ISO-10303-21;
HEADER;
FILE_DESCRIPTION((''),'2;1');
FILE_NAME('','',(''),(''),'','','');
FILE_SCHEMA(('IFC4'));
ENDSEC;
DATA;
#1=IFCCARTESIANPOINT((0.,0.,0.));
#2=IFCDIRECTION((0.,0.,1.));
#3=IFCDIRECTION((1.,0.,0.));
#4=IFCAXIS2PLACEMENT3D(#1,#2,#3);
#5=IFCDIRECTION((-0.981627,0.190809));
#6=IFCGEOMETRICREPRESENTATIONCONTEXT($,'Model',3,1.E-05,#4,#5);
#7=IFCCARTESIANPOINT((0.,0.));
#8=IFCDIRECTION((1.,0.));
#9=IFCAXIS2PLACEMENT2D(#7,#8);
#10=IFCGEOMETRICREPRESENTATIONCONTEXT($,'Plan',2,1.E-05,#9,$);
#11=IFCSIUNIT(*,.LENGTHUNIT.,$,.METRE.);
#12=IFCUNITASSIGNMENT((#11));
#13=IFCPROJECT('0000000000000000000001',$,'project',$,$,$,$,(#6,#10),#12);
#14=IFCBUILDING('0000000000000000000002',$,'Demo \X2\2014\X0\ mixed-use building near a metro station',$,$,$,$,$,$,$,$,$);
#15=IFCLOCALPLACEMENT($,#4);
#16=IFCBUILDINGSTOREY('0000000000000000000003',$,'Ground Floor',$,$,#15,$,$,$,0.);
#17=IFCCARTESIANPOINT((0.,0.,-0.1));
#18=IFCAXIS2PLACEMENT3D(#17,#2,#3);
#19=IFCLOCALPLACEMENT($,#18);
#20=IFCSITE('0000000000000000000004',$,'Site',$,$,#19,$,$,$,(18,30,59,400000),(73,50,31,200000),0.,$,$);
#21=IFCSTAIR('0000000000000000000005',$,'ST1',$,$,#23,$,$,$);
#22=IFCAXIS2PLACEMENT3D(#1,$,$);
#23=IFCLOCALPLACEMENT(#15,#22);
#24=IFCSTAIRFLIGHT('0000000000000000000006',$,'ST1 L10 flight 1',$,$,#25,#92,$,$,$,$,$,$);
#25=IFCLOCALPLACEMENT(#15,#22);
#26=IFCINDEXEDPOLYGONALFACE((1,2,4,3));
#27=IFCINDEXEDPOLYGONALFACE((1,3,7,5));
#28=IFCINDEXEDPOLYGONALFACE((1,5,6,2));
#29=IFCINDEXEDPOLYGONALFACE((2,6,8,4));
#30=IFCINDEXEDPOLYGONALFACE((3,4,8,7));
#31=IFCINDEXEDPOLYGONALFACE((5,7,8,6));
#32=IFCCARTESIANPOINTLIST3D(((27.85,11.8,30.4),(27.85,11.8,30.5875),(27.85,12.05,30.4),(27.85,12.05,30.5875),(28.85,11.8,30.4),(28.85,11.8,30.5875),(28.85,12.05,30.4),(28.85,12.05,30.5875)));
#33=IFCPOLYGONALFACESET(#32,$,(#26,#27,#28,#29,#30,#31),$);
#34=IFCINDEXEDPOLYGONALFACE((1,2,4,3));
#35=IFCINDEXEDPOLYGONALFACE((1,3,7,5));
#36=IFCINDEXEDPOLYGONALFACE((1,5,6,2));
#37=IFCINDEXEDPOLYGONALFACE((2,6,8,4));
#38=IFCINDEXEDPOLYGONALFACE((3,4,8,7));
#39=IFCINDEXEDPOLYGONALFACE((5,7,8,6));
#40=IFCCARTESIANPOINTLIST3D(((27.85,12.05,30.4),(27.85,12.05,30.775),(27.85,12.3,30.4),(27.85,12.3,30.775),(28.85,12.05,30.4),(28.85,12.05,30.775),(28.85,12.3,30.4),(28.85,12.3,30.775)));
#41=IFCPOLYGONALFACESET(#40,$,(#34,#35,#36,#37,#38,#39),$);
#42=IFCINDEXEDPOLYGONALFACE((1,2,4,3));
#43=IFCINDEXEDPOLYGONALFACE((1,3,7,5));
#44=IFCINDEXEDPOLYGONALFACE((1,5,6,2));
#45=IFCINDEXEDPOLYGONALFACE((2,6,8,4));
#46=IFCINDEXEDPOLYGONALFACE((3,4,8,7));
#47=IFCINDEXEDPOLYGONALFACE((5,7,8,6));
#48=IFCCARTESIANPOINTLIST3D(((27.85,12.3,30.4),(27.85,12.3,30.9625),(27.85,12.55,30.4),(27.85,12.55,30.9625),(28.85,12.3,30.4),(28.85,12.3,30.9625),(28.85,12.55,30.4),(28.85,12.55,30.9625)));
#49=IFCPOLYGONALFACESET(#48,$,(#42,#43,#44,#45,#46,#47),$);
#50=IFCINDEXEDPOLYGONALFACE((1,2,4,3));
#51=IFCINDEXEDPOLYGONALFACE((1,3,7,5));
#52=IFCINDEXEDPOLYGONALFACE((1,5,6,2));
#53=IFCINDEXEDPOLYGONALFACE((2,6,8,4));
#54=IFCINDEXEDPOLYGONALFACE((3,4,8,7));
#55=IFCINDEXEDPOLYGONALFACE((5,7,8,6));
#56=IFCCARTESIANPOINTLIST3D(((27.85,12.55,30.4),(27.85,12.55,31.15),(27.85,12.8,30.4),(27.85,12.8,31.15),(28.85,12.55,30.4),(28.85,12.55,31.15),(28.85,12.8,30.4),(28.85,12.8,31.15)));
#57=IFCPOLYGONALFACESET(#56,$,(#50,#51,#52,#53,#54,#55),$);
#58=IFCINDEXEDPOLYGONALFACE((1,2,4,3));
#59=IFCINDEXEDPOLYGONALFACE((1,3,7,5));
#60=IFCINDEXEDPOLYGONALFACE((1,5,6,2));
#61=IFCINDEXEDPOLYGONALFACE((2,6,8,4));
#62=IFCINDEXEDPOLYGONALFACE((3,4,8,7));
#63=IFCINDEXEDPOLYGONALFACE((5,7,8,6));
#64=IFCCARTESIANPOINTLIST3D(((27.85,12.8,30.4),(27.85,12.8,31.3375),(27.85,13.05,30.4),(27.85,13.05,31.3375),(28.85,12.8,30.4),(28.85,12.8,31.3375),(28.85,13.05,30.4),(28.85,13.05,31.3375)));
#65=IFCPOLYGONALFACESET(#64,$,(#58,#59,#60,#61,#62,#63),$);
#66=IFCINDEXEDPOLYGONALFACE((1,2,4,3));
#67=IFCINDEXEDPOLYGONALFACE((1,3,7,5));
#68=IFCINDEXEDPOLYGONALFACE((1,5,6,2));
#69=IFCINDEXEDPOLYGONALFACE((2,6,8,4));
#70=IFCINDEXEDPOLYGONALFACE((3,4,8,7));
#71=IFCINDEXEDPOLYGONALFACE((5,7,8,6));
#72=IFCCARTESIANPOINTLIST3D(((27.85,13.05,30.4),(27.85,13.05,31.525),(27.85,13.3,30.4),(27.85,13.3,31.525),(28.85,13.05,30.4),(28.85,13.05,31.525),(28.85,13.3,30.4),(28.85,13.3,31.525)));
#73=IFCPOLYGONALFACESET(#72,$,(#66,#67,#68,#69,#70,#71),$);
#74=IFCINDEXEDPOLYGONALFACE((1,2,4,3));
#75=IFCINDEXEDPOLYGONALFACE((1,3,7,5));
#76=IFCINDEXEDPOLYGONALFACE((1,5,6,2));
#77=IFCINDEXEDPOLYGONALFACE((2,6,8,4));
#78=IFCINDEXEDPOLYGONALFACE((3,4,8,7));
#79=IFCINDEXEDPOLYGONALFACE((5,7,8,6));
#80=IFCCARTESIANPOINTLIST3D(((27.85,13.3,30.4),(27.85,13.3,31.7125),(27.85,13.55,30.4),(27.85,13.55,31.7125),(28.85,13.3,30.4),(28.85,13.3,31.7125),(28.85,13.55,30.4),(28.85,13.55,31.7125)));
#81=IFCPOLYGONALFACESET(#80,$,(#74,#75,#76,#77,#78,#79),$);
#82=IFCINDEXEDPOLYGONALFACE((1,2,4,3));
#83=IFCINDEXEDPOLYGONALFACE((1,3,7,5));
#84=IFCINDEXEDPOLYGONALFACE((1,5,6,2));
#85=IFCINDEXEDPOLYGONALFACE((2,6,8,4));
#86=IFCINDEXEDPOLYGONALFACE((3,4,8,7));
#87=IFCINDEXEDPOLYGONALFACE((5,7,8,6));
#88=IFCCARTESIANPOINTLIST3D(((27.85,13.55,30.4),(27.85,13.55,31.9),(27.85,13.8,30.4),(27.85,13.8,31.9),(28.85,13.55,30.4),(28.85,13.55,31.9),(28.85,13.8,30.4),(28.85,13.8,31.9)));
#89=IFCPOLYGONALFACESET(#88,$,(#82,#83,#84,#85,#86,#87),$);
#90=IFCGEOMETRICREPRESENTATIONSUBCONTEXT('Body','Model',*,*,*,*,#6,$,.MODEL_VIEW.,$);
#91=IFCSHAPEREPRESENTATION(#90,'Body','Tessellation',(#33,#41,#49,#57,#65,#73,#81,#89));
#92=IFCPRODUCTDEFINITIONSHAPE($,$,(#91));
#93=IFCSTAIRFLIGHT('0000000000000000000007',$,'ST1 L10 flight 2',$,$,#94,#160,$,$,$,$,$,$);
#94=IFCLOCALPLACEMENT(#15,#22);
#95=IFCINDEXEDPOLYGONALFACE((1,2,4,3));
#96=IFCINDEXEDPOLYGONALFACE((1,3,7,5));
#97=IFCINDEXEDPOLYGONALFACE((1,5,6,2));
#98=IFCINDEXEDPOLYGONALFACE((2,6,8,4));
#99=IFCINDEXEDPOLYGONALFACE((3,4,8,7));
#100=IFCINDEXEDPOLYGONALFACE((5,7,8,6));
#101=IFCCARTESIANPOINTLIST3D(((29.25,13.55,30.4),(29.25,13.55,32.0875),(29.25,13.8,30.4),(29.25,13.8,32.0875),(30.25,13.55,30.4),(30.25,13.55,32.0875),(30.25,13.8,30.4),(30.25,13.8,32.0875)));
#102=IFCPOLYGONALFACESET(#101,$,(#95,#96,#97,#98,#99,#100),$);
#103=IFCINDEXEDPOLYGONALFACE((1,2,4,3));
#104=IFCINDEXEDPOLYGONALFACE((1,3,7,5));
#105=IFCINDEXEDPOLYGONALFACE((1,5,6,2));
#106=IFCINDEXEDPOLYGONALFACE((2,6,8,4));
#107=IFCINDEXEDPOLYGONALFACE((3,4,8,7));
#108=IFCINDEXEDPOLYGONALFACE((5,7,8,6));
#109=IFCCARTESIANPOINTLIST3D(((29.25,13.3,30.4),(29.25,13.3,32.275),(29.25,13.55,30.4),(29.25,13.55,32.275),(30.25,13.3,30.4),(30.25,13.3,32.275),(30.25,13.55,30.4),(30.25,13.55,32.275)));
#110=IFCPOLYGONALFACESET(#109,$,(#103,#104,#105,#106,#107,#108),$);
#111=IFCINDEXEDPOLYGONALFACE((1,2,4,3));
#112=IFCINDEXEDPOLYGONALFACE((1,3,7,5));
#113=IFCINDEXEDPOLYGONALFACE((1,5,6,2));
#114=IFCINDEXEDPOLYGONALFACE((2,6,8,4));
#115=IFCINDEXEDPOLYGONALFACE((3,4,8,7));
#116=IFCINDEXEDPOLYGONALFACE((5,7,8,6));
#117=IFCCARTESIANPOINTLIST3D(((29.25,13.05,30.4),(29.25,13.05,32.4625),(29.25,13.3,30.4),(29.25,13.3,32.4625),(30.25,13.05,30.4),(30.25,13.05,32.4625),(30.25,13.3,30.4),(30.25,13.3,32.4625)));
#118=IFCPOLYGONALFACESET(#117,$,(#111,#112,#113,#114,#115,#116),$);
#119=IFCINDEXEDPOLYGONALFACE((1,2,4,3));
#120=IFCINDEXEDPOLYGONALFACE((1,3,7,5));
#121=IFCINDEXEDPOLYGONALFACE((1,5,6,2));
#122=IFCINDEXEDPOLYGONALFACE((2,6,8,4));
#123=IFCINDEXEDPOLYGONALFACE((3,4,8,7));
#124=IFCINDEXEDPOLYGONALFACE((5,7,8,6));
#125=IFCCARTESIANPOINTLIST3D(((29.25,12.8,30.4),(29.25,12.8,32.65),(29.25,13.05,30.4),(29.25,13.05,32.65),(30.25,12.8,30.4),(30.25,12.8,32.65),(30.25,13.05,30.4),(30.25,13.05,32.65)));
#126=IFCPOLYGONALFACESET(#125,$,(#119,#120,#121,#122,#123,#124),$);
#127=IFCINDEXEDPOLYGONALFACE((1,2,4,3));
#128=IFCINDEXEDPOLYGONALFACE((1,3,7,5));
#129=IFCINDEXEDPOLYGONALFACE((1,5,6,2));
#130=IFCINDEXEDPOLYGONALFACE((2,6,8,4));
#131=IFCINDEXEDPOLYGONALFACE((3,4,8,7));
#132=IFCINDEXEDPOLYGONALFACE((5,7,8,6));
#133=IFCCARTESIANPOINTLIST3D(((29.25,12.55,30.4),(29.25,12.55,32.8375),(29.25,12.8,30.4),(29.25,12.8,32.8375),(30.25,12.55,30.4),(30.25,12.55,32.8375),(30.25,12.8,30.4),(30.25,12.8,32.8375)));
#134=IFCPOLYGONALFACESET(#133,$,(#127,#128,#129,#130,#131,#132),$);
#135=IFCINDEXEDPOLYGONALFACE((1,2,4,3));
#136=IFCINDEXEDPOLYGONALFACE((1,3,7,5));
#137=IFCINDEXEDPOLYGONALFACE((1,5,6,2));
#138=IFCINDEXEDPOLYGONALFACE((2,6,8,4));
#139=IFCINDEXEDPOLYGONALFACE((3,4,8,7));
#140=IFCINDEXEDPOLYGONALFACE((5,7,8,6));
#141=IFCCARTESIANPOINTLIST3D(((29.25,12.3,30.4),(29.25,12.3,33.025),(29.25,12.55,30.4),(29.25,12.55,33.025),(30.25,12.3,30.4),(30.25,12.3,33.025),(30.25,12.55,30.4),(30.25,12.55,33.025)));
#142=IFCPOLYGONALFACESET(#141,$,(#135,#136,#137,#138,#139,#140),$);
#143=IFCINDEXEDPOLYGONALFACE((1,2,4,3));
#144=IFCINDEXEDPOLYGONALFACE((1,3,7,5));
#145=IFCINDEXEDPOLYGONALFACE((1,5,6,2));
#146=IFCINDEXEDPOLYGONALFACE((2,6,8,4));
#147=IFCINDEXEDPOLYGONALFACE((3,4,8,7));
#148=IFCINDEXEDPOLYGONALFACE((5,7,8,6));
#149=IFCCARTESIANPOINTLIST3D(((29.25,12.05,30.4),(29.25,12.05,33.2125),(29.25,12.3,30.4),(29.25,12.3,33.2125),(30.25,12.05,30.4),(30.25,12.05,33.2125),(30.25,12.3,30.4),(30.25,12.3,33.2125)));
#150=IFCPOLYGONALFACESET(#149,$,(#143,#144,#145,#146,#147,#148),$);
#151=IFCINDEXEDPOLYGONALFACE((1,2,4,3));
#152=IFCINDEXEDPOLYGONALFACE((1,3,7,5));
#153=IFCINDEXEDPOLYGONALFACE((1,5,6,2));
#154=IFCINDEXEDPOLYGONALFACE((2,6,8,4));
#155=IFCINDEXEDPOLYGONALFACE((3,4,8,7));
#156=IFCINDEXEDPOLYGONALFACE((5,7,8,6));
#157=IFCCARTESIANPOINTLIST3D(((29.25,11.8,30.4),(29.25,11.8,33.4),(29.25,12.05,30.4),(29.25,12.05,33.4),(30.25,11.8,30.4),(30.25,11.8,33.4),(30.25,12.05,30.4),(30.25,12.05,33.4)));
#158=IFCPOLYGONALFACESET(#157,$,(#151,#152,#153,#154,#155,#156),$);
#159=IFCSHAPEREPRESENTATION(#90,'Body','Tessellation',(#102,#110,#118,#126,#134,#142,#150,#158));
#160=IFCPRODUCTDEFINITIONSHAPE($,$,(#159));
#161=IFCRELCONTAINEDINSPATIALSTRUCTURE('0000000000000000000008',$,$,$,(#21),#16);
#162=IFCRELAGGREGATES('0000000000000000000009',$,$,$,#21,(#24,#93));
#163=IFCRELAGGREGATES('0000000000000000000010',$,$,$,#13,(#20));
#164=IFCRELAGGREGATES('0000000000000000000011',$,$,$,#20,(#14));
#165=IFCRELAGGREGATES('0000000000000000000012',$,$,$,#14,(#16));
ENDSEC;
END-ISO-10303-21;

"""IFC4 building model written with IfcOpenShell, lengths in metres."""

from ifc_helpers import new_model, si_unit, direction, frame, origin_with_axes, origin_2d_with_axis, place, context, subcontext, project, spatial, line, indexed_curve, outline, extrude, element, aggregate, save


model = new_model("IFC4")

# Units and contexts
model_context = context("Model", 3, precision=1e-05, world=origin_with_axes(), true_north=direction((-0.981627, 0.190809)))
plan_context = context("Plan", 2, precision=1e-05, world=origin_2d_with_axis())
body_context = subcontext(model_context, "Body", "Model", "MODEL_VIEW")
ifc_project = project(units=[si_unit("LENGTHUNIT", "METRE")], contexts=[model_context, plan_context])

# Site, building, storey
site_placement = place(None, frame((0.0, 0.0, -0.1), z_axis=(0.0, 0.0, 1.0), x_axis=(1.0, 0.0, 0.0)))
site = spatial("IfcSite", under=ifc_project, at=site_placement, Name="Site", RefLatitude=(18, 30, 59, 400000), RefLongitude=(73, 50, 31, 200000), RefElevation=0.0)
building = spatial("IfcBuilding", under=site, Name="Demo — mixed-use building near a metro station")
storey_placement = place(None, origin_with_axes())
storey = spatial("IfcBuildingStorey", under=building, at=storey_placement, Name="Ground Floor", Elevation=0.0)

# Stair, stair flights
stair = element("IfcStair", 1, inside=storey, Name="ST1")
stair_flight_1_placement = place(None, origin_with_axes())
stair_flight_1 = element("IfcStairFlight", 2, at=stair_flight_1_placement, Name="ST1 L10 flight 1", context=body_context, shape_type="SweptSolid", body=[
    extrude(outline(indexed_curve([(27.85, 11.8), (28.85, 11.8), (28.85, 12.05), (27.85, 12.05)], segments=[line(1, 2, 3, 4, 1)])), frame((0.0, 0.0, 30.4), z_axis=(0.0, 0.0, 1.0), x_axis=(1.0, 0.0, 0.0)), (0.0, 0.0, 1.0), 0.1875),
    extrude(outline(indexed_curve([(27.85, 12.05), (28.85, 12.05), (28.85, 12.3), (27.85, 12.3)], segments=[line(1, 2, 3, 4, 1)])), frame((0.0, 0.0, 30.4), z_axis=(0.0, 0.0, 1.0), x_axis=(1.0, 0.0, 0.0)), (0.0, 0.0, 1.0), 0.375),
    extrude(outline(indexed_curve([(27.85, 12.3), (28.85, 12.3), (28.85, 12.55), (27.85, 12.55)], segments=[line(1, 2, 3, 4, 1)])), frame((0.0, 0.0, 30.4), z_axis=(0.0, 0.0, 1.0), x_axis=(1.0, 0.0, 0.0)), (0.0, 0.0, 1.0), 0.5625),
    extrude(outline(indexed_curve([(27.85, 12.55), (28.85, 12.55), (28.85, 12.8), (27.85, 12.8)], segments=[line(1, 2, 3, 4, 1)])), frame((0.0, 0.0, 30.4), z_axis=(0.0, 0.0, 1.0), x_axis=(1.0, 0.0, 0.0)), (0.0, 0.0, 1.0), 0.75),
    extrude(outline(indexed_curve([(27.85, 12.8), (28.85, 12.8), (28.85, 13.05), (27.85, 13.05)], segments=[line(1, 2, 3, 4, 1)])), frame((0.0, 0.0, 30.4), z_axis=(0.0, 0.0, 1.0), x_axis=(1.0, 0.0, 0.0)), (0.0, 0.0, 1.0), 0.9375),
    extrude(outline(indexed_curve([(27.85, 13.05), (28.85, 13.05), (28.85, 13.3), (27.85, 13.3)], segments=[line(1, 2, 3, 4, 1)])), frame((0.0, 0.0, 30.4), z_axis=(0.0, 0.0, 1.0), x_axis=(1.0, 0.0, 0.0)), (0.0, 0.0, 1.0), 1.125),
    extrude(outline(indexed_curve([(27.85, 13.3), (28.85, 13.3), (28.85, 13.55), (27.85, 13.55)], segments=[line(1, 2, 3, 4, 1)])), frame((0.0, 0.0, 30.4), z_axis=(0.0, 0.0, 1.0), x_axis=(1.0, 0.0, 0.0)), (0.0, 0.0, 1.0), 1.3125),
    extrude(outline(indexed_curve([(27.85, 13.55), (28.85, 13.55), (28.85, 13.8), (27.85, 13.8)], segments=[line(1, 2, 3, 4, 1)])), frame((0.0, 0.0, 30.4), z_axis=(0.0, 0.0, 1.0), x_axis=(1.0, 0.0, 0.0)), (0.0, 0.0, 1.0), 1.5),
])
stair_flight_2_placement = place(None, origin_with_axes())
stair_flight_2 = element("IfcStairFlight", 3, at=stair_flight_2_placement, Name="ST1 L10 flight 2", context=body_context, shape_type="SweptSolid", body=[
    extrude(outline(indexed_curve([(29.25, 13.55), (30.25, 13.55), (30.25, 13.8), (29.25, 13.8)], segments=[line(1, 2, 3, 4, 1)])), frame((0.0, 0.0, 30.4), z_axis=(0.0, 0.0, 1.0), x_axis=(1.0, 0.0, 0.0)), (0.0, 0.0, 1.0), 1.6875),
    extrude(outline(indexed_curve([(29.25, 13.3), (30.25, 13.3), (30.25, 13.55), (29.25, 13.55)], segments=[line(1, 2, 3, 4, 1)])), frame((0.0, 0.0, 30.4), z_axis=(0.0, 0.0, 1.0), x_axis=(1.0, 0.0, 0.0)), (0.0, 0.0, 1.0), 1.875),
    extrude(outline(indexed_curve([(29.25, 13.05), (30.25, 13.05), (30.25, 13.3), (29.25, 13.3)], segments=[line(1, 2, 3, 4, 1)])), frame((0.0, 0.0, 30.4), z_axis=(0.0, 0.0, 1.0), x_axis=(1.0, 0.0, 0.0)), (0.0, 0.0, 1.0), 2.0625),
    extrude(outline(indexed_curve([(29.25, 12.8), (30.25, 12.8), (30.25, 13.05), (29.25, 13.05)], segments=[line(1, 2, 3, 4, 1)])), frame((0.0, 0.0, 30.4), z_axis=(0.0, 0.0, 1.0), x_axis=(1.0, 0.0, 0.0)), (0.0, 0.0, 1.0), 2.25),
    extrude(outline(indexed_curve([(29.25, 12.55), (30.25, 12.55), (30.25, 12.8), (29.25, 12.8)], segments=[line(1, 2, 3, 4, 1)])), frame((0.0, 0.0, 30.4), z_axis=(0.0, 0.0, 1.0), x_axis=(1.0, 0.0, 0.0)), (0.0, 0.0, 1.0), 2.4375),
    extrude(outline(indexed_curve([(29.25, 12.3), (30.25, 12.3), (30.25, 12.55), (29.25, 12.55)], segments=[line(1, 2, 3, 4, 1)])), frame((0.0, 0.0, 30.4), z_axis=(0.0, 0.0, 1.0), x_axis=(1.0, 0.0, 0.0)), (0.0, 0.0, 1.0), 2.625),
    extrude(outline(indexed_curve([(29.25, 12.05), (30.25, 12.05), (30.25, 12.3), (29.25, 12.3)], segments=[line(1, 2, 3, 4, 1)])), frame((0.0, 0.0, 30.4), z_axis=(0.0, 0.0, 1.0), x_axis=(1.0, 0.0, 0.0)), (0.0, 0.0, 1.0), 2.8125),
    extrude(outline(indexed_curve([(29.25, 11.8), (30.25, 11.8), (30.25, 12.05), (29.25, 12.05)], segments=[line(1, 2, 3, 4, 1)])), frame((0.0, 0.0, 30.4), z_axis=(0.0, 0.0, 1.0), x_axis=(1.0, 0.0, 0.0)), (0.0, 0.0, 1.0), 3.0),
])
aggregate(stair, [stair_flight_1, stair_flight_2])

save(model, "model.ifc")
